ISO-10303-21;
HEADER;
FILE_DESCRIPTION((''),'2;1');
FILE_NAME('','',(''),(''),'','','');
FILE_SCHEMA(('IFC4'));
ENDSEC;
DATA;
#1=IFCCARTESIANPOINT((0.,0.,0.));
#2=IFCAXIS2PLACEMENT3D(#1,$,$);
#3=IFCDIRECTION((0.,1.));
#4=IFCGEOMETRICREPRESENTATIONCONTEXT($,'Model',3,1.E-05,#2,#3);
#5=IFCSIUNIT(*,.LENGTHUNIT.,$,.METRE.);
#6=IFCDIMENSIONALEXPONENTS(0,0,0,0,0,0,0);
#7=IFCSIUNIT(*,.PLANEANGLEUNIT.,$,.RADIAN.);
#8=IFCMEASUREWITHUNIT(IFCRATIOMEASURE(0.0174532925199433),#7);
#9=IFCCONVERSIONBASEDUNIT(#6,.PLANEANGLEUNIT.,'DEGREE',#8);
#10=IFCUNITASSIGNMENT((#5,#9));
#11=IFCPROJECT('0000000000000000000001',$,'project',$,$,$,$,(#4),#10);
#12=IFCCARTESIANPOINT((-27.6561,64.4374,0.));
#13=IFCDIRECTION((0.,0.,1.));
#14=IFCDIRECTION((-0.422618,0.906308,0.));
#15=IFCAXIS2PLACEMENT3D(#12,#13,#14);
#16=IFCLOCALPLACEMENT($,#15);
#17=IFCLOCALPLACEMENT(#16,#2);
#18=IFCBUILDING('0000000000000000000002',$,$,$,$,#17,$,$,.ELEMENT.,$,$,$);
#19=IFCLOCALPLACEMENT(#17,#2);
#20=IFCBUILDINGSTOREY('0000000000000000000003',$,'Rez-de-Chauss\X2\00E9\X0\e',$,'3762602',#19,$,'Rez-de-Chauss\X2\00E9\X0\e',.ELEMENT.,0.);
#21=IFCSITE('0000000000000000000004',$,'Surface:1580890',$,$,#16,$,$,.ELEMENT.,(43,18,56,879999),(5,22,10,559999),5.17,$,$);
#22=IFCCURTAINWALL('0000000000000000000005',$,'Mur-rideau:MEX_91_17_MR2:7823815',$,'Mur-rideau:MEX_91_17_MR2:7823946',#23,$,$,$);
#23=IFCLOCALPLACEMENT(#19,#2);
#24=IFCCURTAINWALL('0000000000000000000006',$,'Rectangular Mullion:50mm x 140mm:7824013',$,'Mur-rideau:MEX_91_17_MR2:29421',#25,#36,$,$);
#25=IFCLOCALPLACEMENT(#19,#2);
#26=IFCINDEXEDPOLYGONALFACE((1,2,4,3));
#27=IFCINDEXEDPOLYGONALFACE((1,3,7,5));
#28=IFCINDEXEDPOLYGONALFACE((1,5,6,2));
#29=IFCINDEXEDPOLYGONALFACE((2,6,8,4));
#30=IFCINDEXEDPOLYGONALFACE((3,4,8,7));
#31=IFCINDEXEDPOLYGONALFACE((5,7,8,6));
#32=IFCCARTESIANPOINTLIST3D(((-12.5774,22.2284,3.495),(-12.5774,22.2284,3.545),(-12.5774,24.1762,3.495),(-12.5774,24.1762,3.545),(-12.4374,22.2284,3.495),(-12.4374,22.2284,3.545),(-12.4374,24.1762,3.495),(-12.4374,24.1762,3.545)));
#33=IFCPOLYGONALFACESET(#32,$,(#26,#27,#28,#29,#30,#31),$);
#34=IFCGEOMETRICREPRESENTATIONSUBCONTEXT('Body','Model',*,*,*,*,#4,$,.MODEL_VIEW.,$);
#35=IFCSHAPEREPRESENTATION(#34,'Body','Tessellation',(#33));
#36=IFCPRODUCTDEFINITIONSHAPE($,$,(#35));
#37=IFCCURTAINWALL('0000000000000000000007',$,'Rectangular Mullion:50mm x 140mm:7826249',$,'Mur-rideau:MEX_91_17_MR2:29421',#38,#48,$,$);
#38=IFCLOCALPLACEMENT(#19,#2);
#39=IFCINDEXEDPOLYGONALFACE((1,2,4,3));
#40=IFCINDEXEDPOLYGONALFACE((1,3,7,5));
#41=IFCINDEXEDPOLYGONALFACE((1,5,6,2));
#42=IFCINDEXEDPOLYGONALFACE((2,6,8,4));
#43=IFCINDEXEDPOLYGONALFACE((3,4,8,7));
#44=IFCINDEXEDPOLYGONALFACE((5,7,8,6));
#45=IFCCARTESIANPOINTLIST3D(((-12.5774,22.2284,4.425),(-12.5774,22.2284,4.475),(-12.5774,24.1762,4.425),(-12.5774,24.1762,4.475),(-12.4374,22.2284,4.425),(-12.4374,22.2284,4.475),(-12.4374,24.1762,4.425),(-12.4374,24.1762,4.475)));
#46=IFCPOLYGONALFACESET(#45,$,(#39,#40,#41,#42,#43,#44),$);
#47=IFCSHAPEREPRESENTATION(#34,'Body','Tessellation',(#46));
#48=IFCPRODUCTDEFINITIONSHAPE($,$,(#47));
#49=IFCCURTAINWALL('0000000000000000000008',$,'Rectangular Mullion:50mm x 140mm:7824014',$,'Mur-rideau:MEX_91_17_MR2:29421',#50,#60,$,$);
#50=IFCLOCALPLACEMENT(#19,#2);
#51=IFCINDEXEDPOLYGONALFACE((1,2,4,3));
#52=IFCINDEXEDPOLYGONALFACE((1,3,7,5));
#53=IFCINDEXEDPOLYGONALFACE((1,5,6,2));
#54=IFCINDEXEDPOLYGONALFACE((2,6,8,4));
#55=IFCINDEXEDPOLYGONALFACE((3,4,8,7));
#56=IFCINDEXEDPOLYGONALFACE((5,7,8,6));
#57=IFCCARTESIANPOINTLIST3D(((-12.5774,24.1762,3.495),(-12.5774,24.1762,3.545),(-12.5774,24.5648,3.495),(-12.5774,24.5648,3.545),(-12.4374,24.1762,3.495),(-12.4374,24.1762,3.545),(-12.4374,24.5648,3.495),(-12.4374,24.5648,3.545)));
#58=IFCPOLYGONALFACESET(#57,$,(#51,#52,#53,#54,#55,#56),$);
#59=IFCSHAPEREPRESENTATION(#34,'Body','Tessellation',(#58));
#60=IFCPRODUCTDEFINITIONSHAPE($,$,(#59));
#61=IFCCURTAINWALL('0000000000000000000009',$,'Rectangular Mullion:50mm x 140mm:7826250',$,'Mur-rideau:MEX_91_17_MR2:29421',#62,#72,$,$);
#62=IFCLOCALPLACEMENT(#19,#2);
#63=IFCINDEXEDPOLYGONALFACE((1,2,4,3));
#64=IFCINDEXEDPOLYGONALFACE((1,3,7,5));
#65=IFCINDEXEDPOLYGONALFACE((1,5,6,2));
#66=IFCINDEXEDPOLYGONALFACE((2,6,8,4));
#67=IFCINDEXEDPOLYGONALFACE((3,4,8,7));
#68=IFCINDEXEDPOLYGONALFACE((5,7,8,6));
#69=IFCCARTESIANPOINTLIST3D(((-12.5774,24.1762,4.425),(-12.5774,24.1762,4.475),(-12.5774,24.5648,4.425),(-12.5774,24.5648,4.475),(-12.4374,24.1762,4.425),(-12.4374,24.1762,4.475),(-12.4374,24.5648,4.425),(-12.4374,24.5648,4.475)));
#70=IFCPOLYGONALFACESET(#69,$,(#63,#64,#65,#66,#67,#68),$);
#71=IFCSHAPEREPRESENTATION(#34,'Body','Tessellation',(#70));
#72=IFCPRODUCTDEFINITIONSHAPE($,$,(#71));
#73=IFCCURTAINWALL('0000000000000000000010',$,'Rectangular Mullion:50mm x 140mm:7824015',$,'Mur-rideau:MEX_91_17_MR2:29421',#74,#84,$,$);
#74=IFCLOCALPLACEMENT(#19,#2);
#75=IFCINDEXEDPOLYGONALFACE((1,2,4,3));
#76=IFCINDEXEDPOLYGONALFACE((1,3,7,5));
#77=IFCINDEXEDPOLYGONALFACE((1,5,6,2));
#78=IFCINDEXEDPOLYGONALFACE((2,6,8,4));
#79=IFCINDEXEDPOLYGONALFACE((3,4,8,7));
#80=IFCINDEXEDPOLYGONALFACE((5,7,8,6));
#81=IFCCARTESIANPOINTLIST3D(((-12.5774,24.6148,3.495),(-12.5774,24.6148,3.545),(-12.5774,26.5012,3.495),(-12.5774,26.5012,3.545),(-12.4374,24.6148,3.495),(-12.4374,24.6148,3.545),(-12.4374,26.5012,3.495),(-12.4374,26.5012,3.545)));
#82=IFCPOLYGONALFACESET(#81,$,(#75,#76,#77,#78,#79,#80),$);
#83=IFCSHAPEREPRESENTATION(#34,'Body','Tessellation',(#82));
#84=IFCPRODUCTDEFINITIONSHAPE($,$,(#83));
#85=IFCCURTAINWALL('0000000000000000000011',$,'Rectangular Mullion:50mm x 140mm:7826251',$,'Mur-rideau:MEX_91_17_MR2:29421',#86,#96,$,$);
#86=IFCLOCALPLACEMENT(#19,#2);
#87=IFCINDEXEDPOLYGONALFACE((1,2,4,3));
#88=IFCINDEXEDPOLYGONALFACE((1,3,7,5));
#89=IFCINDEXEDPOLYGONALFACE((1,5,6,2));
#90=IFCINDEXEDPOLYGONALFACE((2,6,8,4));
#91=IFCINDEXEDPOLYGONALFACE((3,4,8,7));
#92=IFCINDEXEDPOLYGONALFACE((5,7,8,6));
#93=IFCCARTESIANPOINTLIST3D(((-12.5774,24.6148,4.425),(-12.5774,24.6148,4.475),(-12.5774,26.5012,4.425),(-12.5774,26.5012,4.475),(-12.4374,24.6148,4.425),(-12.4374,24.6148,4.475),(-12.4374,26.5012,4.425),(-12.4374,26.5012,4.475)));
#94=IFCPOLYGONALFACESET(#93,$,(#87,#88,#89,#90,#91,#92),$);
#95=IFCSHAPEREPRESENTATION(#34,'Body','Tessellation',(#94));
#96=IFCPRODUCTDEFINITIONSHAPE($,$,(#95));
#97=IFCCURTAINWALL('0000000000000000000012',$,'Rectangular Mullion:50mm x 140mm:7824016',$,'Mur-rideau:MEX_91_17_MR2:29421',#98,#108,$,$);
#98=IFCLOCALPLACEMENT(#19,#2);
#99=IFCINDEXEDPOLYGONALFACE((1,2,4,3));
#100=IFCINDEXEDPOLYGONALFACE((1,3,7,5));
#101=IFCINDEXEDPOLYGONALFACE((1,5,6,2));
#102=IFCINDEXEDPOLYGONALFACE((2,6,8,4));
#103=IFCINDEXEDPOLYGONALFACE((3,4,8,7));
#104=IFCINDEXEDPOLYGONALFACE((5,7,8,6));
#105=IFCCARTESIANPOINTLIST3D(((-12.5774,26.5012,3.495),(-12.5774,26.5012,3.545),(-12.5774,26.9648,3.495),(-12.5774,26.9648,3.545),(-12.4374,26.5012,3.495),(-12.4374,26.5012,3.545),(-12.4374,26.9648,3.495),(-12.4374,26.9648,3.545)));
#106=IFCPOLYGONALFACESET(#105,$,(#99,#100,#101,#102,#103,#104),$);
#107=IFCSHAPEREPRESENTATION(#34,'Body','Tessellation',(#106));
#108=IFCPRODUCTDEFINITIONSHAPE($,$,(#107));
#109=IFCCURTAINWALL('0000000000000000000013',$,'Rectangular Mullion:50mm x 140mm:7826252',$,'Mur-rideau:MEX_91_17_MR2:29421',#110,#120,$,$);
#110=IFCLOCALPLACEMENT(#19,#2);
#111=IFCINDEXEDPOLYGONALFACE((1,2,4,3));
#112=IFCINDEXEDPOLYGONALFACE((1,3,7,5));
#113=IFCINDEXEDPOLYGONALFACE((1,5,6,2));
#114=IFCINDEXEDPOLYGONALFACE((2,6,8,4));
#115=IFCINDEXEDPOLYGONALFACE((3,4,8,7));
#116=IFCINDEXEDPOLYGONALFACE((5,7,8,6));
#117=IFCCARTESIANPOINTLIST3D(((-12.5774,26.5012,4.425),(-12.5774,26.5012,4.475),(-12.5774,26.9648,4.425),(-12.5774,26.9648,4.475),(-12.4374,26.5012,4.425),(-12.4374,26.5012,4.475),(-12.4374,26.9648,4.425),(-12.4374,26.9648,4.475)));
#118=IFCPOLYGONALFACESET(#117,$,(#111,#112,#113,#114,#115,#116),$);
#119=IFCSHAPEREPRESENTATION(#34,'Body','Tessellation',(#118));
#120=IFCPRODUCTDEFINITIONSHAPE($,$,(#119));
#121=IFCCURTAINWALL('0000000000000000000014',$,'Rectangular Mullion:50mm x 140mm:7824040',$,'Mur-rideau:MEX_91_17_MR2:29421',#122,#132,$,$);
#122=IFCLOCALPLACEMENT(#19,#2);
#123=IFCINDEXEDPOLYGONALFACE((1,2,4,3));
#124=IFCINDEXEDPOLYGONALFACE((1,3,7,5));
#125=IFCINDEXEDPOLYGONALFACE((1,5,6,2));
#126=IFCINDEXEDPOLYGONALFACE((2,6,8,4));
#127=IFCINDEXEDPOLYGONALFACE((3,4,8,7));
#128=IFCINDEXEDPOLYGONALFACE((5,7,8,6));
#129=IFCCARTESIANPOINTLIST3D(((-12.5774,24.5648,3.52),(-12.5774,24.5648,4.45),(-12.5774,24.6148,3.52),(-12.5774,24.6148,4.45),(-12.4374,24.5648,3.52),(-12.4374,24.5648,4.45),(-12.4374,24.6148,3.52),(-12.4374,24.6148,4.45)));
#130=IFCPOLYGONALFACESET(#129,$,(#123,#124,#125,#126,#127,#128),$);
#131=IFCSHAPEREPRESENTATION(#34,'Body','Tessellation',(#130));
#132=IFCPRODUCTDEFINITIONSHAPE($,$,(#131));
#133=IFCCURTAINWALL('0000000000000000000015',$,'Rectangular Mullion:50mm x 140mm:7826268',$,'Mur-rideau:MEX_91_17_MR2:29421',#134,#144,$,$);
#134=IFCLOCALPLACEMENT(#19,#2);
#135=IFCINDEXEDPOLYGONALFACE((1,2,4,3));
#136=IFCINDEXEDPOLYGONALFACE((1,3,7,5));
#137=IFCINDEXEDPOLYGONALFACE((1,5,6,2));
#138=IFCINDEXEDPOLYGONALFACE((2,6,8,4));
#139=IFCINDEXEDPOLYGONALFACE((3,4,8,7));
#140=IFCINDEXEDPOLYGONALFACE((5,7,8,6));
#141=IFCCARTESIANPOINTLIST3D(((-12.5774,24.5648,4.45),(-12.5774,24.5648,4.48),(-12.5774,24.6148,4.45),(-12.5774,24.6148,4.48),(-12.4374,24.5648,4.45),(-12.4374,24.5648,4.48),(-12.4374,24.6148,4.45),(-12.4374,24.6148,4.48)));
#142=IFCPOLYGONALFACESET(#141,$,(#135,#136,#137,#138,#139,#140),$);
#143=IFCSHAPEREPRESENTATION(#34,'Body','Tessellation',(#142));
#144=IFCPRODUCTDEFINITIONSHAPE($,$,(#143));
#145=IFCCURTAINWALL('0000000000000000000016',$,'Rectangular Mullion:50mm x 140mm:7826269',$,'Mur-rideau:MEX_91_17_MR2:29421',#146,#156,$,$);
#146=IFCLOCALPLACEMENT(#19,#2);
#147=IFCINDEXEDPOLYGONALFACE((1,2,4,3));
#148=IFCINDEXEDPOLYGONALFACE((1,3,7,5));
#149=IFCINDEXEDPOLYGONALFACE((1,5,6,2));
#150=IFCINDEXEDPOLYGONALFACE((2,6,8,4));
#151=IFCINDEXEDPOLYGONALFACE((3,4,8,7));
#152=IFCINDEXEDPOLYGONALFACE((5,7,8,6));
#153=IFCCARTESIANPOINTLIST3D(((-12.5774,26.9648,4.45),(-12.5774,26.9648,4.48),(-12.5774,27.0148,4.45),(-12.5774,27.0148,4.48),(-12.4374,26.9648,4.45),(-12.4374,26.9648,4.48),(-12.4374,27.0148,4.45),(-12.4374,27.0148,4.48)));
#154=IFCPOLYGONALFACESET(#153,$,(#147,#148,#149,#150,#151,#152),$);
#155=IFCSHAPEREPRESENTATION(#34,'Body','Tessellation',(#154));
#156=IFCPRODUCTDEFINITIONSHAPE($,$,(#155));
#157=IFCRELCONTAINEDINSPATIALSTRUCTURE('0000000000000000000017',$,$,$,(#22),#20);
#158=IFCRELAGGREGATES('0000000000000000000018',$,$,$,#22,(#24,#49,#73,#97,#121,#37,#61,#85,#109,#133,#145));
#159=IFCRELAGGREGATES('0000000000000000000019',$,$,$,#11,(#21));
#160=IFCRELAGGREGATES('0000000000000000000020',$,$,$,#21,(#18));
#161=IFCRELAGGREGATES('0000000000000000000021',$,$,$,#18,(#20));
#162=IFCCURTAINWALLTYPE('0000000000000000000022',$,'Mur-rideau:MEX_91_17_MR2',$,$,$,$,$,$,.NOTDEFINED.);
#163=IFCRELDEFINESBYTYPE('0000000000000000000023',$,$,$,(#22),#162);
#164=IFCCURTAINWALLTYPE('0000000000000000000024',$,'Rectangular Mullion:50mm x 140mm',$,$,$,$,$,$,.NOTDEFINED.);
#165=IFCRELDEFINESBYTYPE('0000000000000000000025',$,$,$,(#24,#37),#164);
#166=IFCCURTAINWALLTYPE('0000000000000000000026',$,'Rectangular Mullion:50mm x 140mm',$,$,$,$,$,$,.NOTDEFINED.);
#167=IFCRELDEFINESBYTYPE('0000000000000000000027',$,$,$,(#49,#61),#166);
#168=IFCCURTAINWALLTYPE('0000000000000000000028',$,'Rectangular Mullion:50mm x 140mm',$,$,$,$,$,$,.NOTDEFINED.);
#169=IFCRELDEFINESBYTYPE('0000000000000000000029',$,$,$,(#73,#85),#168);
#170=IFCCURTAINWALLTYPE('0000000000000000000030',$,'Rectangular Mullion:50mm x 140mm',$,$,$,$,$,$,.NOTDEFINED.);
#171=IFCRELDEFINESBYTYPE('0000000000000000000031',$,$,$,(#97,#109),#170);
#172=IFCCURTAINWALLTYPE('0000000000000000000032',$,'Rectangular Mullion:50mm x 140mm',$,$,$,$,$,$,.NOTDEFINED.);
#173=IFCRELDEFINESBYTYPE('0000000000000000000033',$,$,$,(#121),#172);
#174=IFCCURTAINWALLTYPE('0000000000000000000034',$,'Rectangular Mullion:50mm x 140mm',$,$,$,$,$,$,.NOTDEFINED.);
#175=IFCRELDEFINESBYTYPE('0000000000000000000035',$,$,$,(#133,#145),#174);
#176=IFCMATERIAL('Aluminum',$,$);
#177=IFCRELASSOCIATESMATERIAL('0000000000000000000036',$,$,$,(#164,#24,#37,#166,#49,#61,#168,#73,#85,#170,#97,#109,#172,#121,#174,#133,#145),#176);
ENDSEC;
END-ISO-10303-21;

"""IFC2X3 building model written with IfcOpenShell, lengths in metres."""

from ifc_helpers import new_model, entity, si_unit, converted_unit, direction, frame, origin, origin_2d_with_axis, place, context, subcontext, project, spatial, rectangle, extrude, source, transform, mapped, material, type_object, type_shapes, element, aggregate, save


model = new_model("IFC2X3")

# Units and contexts
model_context = context("Model", 3, precision=1e-05, world=origin(), true_north=direction((0.0, 1.0)))
body_context = subcontext(model_context, "Body", "Model", "MODEL_VIEW")
ifc_project = project(units=[si_unit("LENGTHUNIT", "METRE"), converted_unit("PLANEANGLEUNIT", "DEGREE", entity("IfcRatioMeasure", 0.0174532925199433), si_unit("PLANEANGLEUNIT", "RADIAN"), dimensions=[0, 0, 0, 0, 0, 0, 0])], contexts=[model_context])

# Site, building, storey
site_placement = place(None, frame((-27.6561, 64.4374, 0.0), z_axis=(0.0, 0.0, 1.0), x_axis=(-0.422618, 0.906308, 0.0)))
site = spatial("IfcSite", under=ifc_project, at=site_placement, Name="Surface:1580890", CompositionType="ELEMENT", RefLatitude=(43, 18, 56, 879999), RefLongitude=(5, 22, 10, 559999), RefElevation=5.17)
building_placement = place(site_placement, origin())
building = spatial("IfcBuilding", under=site, at=building_placement, CompositionType="ELEMENT")
storey_placement = place(building_placement, origin())
storey = spatial("IfcBuildingStorey", under=building, at=storey_placement, Name="Rez-de-Chaussée", ObjectType="3762602", LongName="Rez-de-Chaussée", CompositionType="ELEMENT", Elevation=0.0)

# Curtain walls
curtain_wall_type_1 = type_object("IfcCurtainWallType", Name="Mur-rideau:MEX_91_17_MR2", PredefinedType="NOTDEFINED")
curtain_wall_1_placement = place(storey_placement, origin())
curtain_wall_1 = element("IfcCurtainWall", 1, at=curtain_wall_1_placement, inside=storey, type_object=curtain_wall_type_1, Name="Mur-rideau:MEX_91_17_MR2:7823815", ObjectType="Mur-rideau:MEX_91_17_MR2:7823946")
ifc_material_1 = material(Name="Aluminum")
curtain_wall_type_2 = type_object("IfcCurtainWallType", Name="Rectangular Mullion:50mm x 140mm", PredefinedType="NOTDEFINED", material=ifc_material_1)
shared_shape_1 = source(origin(), body_context, "Body", "SweptSolid", [
    extrude(rectangle(XDim=0.05, YDim=0.14, at=origin_2d_with_axis()), frame((0.0, 0.0, -1.9477), z_axis=(0.0, 0.0, 1.0), x_axis=(-1.0, 0.0, 0.0)), (0.0, 0.0, 1.0), 1.9477),
])
type_shapes(curtain_wall_type_2, [shared_shape_1])
curtain_wall_2_placement = place(storey_placement, frame((-12.5074, 24.1762, 3.52), z_axis=(0.0, 1.0, 0.0), x_axis=(0.0, 0.0, 1.0)))
curtain_wall_2 = element("IfcCurtainWall", 2, at=curtain_wall_2_placement, type_object=curtain_wall_type_2, material=ifc_material_1, Name="Rectangular Mullion:50mm x 140mm:7824013", ObjectType="Mur-rideau:MEX_91_17_MR2:29421", context=body_context, shape_type="MappedRepresentation", body=[
    mapped(shared_shape_1, transform((0.0, 0.0, 0.0), scale=1.0)),
])
curtain_wall_3_placement = place(storey_placement, frame((-12.5074, 24.1762, 4.45), z_axis=(0.0, 1.0, 0.0), x_axis=(0.0, 0.0, 1.0)))
curtain_wall_3 = element("IfcCurtainWall", 3, at=curtain_wall_3_placement, type_object=curtain_wall_type_2, material=ifc_material_1, Name="Rectangular Mullion:50mm x 140mm:7826249", ObjectType="Mur-rideau:MEX_91_17_MR2:29421", context=body_context, shape_type="MappedRepresentation", body=[
    mapped(shared_shape_1, transform((0.0, 0.0, 0.0), scale=1.0)),
])
curtain_wall_type_3 = type_object("IfcCurtainWallType", Name="Rectangular Mullion:50mm x 140mm", PredefinedType="NOTDEFINED", material=ifc_material_1)
shared_shape_2 = source(origin(), body_context, "Body", "SweptSolid", [
    extrude(rectangle(XDim=0.05, YDim=0.14, at=origin_2d_with_axis()), frame((0.0, 0.0, -0.3886), z_axis=(0.0, 0.0, 1.0), x_axis=(-1.0, 0.0, 0.0)), (0.0, 0.0, 1.0), 0.3886),
])
type_shapes(curtain_wall_type_3, [shared_shape_2])
curtain_wall_4_placement = place(storey_placement, frame((-12.5074, 24.5648, 3.52), z_axis=(0.0, 1.0, 0.0), x_axis=(0.0, 0.0, 1.0)))
curtain_wall_4 = element("IfcCurtainWall", 4, at=curtain_wall_4_placement, type_object=curtain_wall_type_3, material=ifc_material_1, Name="Rectangular Mullion:50mm x 140mm:7824014", ObjectType="Mur-rideau:MEX_91_17_MR2:29421", context=body_context, shape_type="MappedRepresentation", body=[
    mapped(shared_shape_2, transform((0.0, 0.0, 0.0), scale=1.0)),
])
curtain_wall_5_placement = place(storey_placement, frame((-12.5074, 24.5648, 4.45), z_axis=(0.0, 1.0, 0.0), x_axis=(0.0, 0.0, 1.0)))
curtain_wall_5 = element("IfcCurtainWall", 5, at=curtain_wall_5_placement, type_object=curtain_wall_type_3, material=ifc_material_1, Name="Rectangular Mullion:50mm x 140mm:7826250", ObjectType="Mur-rideau:MEX_91_17_MR2:29421", context=body_context, shape_type="MappedRepresentation", body=[
    mapped(shared_shape_2, transform((0.0, 0.0, 0.0), scale=1.0)),
])
curtain_wall_type_4 = type_object("IfcCurtainWallType", Name="Rectangular Mullion:50mm x 140mm", PredefinedType="NOTDEFINED", material=ifc_material_1)
shared_shape_3 = source(origin(), body_context, "Body", "SweptSolid", [
    extrude(rectangle(XDim=0.05, YDim=0.14, at=origin_2d_with_axis()), frame((0.0, 0.0, -1.8864), z_axis=(0.0, 0.0, 1.0), x_axis=(-1.0, 0.0, 0.0)), (0.0, 0.0, 1.0), 1.8864),
])
type_shapes(curtain_wall_type_4, [shared_shape_3])
curtain_wall_6_placement = place(storey_placement, frame((-12.5074, 26.5012, 3.52), z_axis=(0.0, 1.0, 0.0), x_axis=(0.0, 0.0, 1.0)))
curtain_wall_6 = element("IfcCurtainWall", 6, at=curtain_wall_6_placement, type_object=curtain_wall_type_4, material=ifc_material_1, Name="Rectangular Mullion:50mm x 140mm:7824015", ObjectType="Mur-rideau:MEX_91_17_MR2:29421", context=body_context, shape_type="MappedRepresentation", body=[
    mapped(shared_shape_3, transform((0.0, 0.0, 0.0), scale=1.0)),
])
curtain_wall_7_placement = place(storey_placement, frame((-12.5074, 26.5012, 4.45), z_axis=(0.0, 1.0, 0.0), x_axis=(0.0, 0.0, 1.0)))
curtain_wall_7 = element("IfcCurtainWall", 7, at=curtain_wall_7_placement, type_object=curtain_wall_type_4, material=ifc_material_1, Name="Rectangular Mullion:50mm x 140mm:7826251", ObjectType="Mur-rideau:MEX_91_17_MR2:29421", context=body_context, shape_type="MappedRepresentation", body=[
    mapped(shared_shape_3, transform((0.0, 0.0, 0.0), scale=1.0)),
])
curtain_wall_type_5 = type_object("IfcCurtainWallType", Name="Rectangular Mullion:50mm x 140mm", PredefinedType="NOTDEFINED", material=ifc_material_1)
shared_shape_4 = source(origin(), body_context, "Body", "SweptSolid", [
    extrude(rectangle(XDim=0.05, YDim=0.14, at=origin_2d_with_axis()), frame((0.0, 0.0, -0.4636), z_axis=(0.0, 0.0, 1.0), x_axis=(-1.0, 0.0, 0.0)), (0.0, 0.0, 1.0), 0.4636),
])
type_shapes(curtain_wall_type_5, [shared_shape_4])
curtain_wall_8_placement = place(storey_placement, frame((-12.5074, 26.9648, 3.52), z_axis=(0.0, 1.0, 0.0), x_axis=(0.0, 0.0, 1.0)))
curtain_wall_8 = element("IfcCurtainWall", 8, at=curtain_wall_8_placement, type_object=curtain_wall_type_5, material=ifc_material_1, Name="Rectangular Mullion:50mm x 140mm:7824016", ObjectType="Mur-rideau:MEX_91_17_MR2:29421", context=body_context, shape_type="MappedRepresentation", body=[
    mapped(shared_shape_4, transform((0.0, 0.0, 0.0), scale=1.0)),
])
curtain_wall_9_placement = place(storey_placement, frame((-12.5074, 26.9648, 4.45), z_axis=(0.0, 1.0, 0.0), x_axis=(0.0, 0.0, 1.0)))
curtain_wall_9 = element("IfcCurtainWall", 9, at=curtain_wall_9_placement, type_object=curtain_wall_type_5, material=ifc_material_1, Name="Rectangular Mullion:50mm x 140mm:7826252", ObjectType="Mur-rideau:MEX_91_17_MR2:29421", context=body_context, shape_type="MappedRepresentation", body=[
    mapped(shared_shape_4, transform((0.0, 0.0, 0.0), scale=1.0)),
])
curtain_wall_type_6 = type_object("IfcCurtainWallType", Name="Rectangular Mullion:50mm x 140mm", PredefinedType="NOTDEFINED", material=ifc_material_1)
shared_shape_5 = source(origin(), body_context, "Body", "SweptSolid", [
    extrude(rectangle(XDim=0.05, YDim=0.14, at=origin_2d_with_axis()), frame((0.0, 0.0, -0.93), z_axis=(0.0, 0.0, 1.0), x_axis=(-1.0, 0.0, 0.0)), (0.0, 0.0, 1.0), 0.93),
])
type_shapes(curtain_wall_type_6, [shared_shape_5])
curtain_wall_10_placement = place(storey_placement, frame((-12.5074, 24.5898, 3.52), z_axis=(0.0, 0.0, -1.0), x_axis=(0.0, 1.0, 0.0)))
curtain_wall_10 = element("IfcCurtainWall", 10, at=curtain_wall_10_placement, type_object=curtain_wall_type_6, material=ifc_material_1, Name="Rectangular Mullion:50mm x 140mm:7824040", ObjectType="Mur-rideau:MEX_91_17_MR2:29421", context=body_context, shape_type="MappedRepresentation", body=[
    mapped(shared_shape_5, transform((0.0, 0.0, 0.0), scale=1.0)),
])
curtain_wall_type_7 = type_object("IfcCurtainWallType", Name="Rectangular Mullion:50mm x 140mm", PredefinedType="NOTDEFINED", material=ifc_material_1)
shared_shape_6 = source(origin(), body_context, "Body", "SweptSolid", [
    extrude(rectangle(XDim=0.05, YDim=0.14, at=origin_2d_with_axis()), frame((0.0, 0.0, -0.03), z_axis=(0.0, 0.0, 1.0), x_axis=(-1.0, 0.0, 0.0)), (0.0, 0.0, 1.0), 0.03),
])
type_shapes(curtain_wall_type_7, [shared_shape_6])
curtain_wall_11_placement = place(storey_placement, frame((-12.5074, 24.5898, 4.45), z_axis=(0.0, 0.0, -1.0), x_axis=(0.0, 1.0, 0.0)))
curtain_wall_11 = element("IfcCurtainWall", 11, at=curtain_wall_11_placement, type_object=curtain_wall_type_7, material=ifc_material_1, Name="Rectangular Mullion:50mm x 140mm:7826268", ObjectType="Mur-rideau:MEX_91_17_MR2:29421", context=body_context, shape_type="MappedRepresentation", body=[
    mapped(shared_shape_6, transform((0.0, 0.0, 0.0), scale=1.0)),
])
curtain_wall_12_placement = place(storey_placement, frame((-12.5074, 26.9898, 4.45), z_axis=(0.0, 0.0, -1.0), x_axis=(0.0, 1.0, 0.0)))
curtain_wall_12 = element("IfcCurtainWall", 12, at=curtain_wall_12_placement, type_object=curtain_wall_type_7, material=ifc_material_1, Name="Rectangular Mullion:50mm x 140mm:7826269", ObjectType="Mur-rideau:MEX_91_17_MR2:29421", context=body_context, shape_type="MappedRepresentation", body=[
    mapped(shared_shape_6, transform((0.0, 0.0, 0.0), scale=1.0)),
])
aggregate(curtain_wall_1, [curtain_wall_2, curtain_wall_4, curtain_wall_6, curtain_wall_8, curtain_wall_10, curtain_wall_3, curtain_wall_5, curtain_wall_7, curtain_wall_9, curtain_wall_11, curtain_wall_12])

save(model, "model.ifc")
